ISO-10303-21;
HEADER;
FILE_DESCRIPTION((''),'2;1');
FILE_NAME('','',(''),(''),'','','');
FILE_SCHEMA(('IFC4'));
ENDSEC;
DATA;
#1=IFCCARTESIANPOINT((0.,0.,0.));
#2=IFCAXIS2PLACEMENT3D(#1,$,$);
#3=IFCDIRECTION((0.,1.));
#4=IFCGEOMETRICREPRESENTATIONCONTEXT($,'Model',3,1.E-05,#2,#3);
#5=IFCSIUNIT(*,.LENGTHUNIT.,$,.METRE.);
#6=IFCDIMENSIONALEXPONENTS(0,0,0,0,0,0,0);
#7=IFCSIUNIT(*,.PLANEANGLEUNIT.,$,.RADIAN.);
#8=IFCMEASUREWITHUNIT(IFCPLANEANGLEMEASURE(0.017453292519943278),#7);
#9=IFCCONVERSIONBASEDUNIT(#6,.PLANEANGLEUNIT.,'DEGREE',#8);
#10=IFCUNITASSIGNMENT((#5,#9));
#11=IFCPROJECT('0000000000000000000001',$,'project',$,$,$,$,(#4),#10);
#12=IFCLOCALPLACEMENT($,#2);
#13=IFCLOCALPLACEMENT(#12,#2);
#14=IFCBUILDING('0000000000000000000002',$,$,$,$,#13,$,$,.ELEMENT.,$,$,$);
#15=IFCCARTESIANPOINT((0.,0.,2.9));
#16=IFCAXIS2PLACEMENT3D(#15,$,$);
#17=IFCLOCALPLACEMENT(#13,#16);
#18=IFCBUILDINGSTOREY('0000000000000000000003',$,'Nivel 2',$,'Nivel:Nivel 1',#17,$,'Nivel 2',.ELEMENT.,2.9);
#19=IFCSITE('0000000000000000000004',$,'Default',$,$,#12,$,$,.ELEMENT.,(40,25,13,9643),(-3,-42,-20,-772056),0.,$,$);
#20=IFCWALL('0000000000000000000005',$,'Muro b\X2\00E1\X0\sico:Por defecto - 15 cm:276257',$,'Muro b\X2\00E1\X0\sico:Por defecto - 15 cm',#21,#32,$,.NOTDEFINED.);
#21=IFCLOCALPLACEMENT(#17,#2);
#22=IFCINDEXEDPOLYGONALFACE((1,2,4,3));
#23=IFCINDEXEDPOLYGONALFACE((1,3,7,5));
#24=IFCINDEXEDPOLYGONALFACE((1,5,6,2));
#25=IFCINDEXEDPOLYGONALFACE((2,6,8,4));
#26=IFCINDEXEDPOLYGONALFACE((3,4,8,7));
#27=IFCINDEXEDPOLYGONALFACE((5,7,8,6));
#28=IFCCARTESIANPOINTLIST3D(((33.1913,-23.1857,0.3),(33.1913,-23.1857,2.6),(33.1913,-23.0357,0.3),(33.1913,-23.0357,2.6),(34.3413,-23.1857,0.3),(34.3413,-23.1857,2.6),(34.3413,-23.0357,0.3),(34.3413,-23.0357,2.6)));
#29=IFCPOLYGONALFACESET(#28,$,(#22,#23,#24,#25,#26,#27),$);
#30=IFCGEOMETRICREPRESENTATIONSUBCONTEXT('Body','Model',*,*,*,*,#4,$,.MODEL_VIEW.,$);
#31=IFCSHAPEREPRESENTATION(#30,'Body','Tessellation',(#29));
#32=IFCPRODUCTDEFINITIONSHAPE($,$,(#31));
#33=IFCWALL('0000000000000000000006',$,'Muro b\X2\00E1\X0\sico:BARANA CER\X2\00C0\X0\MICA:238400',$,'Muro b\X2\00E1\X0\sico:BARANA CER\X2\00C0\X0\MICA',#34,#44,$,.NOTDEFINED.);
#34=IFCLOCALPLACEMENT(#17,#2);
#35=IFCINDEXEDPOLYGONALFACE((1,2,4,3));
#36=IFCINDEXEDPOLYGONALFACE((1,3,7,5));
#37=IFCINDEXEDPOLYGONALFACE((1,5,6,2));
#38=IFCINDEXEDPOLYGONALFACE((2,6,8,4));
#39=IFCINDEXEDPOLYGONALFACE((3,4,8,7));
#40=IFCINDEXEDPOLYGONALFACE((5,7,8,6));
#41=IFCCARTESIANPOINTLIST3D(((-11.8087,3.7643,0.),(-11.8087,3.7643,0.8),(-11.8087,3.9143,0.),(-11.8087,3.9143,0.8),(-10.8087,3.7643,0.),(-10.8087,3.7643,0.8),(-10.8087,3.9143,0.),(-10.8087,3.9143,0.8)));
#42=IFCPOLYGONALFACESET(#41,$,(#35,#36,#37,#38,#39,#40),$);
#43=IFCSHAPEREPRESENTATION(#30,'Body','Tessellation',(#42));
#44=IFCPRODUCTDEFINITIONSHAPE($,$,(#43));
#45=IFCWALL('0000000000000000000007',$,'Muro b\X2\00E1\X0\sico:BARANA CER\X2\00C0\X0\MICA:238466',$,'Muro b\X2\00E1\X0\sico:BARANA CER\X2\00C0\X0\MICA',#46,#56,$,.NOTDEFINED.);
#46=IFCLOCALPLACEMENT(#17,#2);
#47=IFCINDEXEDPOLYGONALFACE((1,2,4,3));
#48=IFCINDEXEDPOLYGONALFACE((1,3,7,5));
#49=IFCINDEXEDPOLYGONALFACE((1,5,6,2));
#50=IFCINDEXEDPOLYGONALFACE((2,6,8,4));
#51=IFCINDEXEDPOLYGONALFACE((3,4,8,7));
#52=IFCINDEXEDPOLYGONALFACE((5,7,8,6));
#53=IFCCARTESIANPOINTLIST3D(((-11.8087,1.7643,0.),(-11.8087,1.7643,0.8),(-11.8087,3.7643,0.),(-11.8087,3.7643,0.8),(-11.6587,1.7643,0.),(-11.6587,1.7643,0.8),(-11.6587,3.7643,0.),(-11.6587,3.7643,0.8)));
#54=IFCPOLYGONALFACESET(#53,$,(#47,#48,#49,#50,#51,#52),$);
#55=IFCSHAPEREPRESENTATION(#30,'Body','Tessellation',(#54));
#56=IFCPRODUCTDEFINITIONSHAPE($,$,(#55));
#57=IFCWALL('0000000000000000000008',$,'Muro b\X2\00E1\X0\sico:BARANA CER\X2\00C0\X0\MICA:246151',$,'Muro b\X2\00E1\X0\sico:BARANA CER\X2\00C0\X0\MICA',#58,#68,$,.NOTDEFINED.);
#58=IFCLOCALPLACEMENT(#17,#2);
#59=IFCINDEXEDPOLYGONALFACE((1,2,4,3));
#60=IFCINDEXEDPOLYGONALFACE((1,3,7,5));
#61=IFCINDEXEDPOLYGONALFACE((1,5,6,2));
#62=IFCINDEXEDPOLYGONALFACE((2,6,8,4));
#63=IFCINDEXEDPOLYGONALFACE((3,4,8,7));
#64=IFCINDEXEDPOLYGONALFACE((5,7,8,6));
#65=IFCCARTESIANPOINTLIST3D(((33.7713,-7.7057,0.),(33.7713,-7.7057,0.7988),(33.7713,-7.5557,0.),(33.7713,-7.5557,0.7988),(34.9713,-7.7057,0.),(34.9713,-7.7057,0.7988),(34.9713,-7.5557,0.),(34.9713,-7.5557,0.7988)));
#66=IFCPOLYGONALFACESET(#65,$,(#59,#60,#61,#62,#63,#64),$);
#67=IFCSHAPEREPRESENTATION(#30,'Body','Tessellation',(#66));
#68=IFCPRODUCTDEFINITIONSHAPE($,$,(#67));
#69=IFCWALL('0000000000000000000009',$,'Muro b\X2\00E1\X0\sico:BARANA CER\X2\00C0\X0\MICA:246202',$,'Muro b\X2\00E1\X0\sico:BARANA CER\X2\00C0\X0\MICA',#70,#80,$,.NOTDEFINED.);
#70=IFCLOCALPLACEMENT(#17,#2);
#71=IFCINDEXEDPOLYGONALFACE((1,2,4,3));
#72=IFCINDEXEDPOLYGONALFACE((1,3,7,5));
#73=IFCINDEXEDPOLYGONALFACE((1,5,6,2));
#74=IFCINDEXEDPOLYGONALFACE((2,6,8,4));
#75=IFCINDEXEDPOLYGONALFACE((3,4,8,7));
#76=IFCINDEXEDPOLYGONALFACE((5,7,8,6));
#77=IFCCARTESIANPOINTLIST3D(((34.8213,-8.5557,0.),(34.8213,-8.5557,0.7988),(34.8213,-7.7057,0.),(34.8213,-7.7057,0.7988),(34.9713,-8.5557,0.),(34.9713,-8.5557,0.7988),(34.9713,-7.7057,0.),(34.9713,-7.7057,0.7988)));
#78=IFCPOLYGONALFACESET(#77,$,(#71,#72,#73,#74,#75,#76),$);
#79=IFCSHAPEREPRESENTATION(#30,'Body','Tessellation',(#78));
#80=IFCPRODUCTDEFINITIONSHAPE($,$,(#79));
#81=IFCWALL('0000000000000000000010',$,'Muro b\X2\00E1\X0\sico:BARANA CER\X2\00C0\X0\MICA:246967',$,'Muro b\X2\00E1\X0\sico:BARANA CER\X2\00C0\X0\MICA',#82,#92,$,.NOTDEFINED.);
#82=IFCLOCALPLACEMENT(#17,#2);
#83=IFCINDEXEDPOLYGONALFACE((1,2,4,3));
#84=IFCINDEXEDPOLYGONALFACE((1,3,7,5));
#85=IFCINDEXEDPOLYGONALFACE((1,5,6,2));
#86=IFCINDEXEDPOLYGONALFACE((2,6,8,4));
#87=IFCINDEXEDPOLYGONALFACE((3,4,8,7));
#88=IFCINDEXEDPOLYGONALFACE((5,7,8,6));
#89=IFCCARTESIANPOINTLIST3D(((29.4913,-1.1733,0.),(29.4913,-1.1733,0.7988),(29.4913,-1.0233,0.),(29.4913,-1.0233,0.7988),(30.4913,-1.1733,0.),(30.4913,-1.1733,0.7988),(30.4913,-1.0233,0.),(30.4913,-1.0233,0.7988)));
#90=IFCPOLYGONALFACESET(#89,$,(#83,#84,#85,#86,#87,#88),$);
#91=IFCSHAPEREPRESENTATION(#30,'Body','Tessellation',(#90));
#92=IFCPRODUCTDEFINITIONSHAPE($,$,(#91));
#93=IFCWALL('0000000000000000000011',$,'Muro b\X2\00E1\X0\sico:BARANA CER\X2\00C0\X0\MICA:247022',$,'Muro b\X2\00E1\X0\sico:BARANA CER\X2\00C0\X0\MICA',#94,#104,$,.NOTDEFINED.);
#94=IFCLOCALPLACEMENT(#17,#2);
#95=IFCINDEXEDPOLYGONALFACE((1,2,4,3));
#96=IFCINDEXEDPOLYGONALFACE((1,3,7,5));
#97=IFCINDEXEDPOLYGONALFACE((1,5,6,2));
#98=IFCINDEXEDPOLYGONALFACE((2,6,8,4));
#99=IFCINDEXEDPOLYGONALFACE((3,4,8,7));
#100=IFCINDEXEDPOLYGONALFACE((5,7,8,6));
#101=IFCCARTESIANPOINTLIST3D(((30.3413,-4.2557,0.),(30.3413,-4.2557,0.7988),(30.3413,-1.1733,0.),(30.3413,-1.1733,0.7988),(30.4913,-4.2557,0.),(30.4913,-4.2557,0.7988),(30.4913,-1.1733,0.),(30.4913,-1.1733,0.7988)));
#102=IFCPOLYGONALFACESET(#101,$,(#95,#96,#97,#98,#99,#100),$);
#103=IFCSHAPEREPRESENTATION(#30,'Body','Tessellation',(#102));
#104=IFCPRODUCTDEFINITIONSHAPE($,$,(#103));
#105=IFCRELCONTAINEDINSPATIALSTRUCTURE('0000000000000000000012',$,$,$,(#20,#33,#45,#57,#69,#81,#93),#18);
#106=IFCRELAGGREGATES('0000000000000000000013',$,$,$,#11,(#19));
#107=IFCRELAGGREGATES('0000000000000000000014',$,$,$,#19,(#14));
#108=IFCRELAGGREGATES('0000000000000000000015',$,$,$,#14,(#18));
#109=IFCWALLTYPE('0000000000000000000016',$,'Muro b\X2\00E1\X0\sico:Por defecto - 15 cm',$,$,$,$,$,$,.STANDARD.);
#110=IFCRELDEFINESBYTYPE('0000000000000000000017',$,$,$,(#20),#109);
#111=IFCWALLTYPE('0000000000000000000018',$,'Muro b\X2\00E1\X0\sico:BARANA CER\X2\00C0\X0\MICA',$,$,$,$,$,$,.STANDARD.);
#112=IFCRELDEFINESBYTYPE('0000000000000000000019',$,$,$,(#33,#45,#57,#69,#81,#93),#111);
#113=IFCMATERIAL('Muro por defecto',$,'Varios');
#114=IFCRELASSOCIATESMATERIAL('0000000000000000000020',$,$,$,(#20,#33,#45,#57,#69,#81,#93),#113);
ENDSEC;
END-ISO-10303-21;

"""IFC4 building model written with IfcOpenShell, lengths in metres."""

from ifc_helpers import new_model, entity, si_unit, converted_unit, direction, frame, origin, place, context, subcontext, project, spatial, indexed_curve, outline, extrude, material, type_object, element, save


model = new_model("IFC4")

# Units and contexts
model_context = context("Model", 3, precision=1e-05, world=origin(), true_north=direction((0.0, 1.0)))
body_context = subcontext(model_context, "Body", "Model", "MODEL_VIEW")
ifc_project = project(units=[si_unit("LENGTHUNIT", "METRE"), converted_unit("PLANEANGLEUNIT", "DEGREE", entity("IfcPlaneAngleMeasure", 0.017453292519943278), si_unit("PLANEANGLEUNIT", "RADIAN"), dimensions=[0, 0, 0, 0, 0, 0, 0])], contexts=[model_context])

# Site, building, storey
site_placement = place(None, origin())
site = spatial("IfcSite", under=ifc_project, at=site_placement, Name="Default", CompositionType="ELEMENT", RefLatitude=(40, 25, 13, 9643), RefLongitude=(-3, -42, -20, -772056), RefElevation=0.0)
building_placement = place(site_placement, origin())
building = spatial("IfcBuilding", under=site, at=building_placement, CompositionType="ELEMENT")
storey_placement = place(building_placement, frame((0.0, 0.0, 2.9)))
storey = spatial("IfcBuildingStorey", under=building, at=storey_placement, Name="Nivel 2", ObjectType="Nivel:Nivel 1", LongName="Nivel 2", CompositionType="ELEMENT", Elevation=2.9)

# Shared definitions
ifc_material_1 = material(Name="Muro por defecto", Category="Varios")
wall_type_1 = type_object("IfcWallType", Name="Muro básico:Por defecto - 15 cm", PredefinedType="STANDARD")

# Walls
wall_1_placement = place(storey_placement, frame((33.1913, -23.1107, 0.3)))
element("IfcWall", 1, at=wall_1_placement, inside=storey, type_object=wall_type_1, material=ifc_material_1, Name="Muro básico:Por defecto - 15 cm:276257", ObjectType="Muro básico:Por defecto - 15 cm", PredefinedType="NOTDEFINED", context=body_context, shape_type="SweptSolid", body=[
    extrude(outline(indexed_curve([(1.15, 0.075), (0.0, 0.075), (0.0, -0.075), (1.15, -0.075), (1.15, 0.075)], self_intersect=False)), origin(), (0.0, 0.0, 1.0), 2.3),
])
wall_type_2 = type_object("IfcWallType", Name="Muro básico:BARANA CERÀMICA", PredefinedType="STANDARD")
wall_2_placement = place(storey_placement, frame((-10.8087, 3.8393, 0.0), z_axis=(0.0, 0.0, 1.0), x_axis=(-1.0, 0.0, 0.0)))
element("IfcWall", 2, at=wall_2_placement, inside=storey, type_object=wall_type_2, material=ifc_material_1, Name="Muro básico:BARANA CERÀMICA:238400", ObjectType="Muro básico:BARANA CERÀMICA", PredefinedType="NOTDEFINED", context=body_context, shape_type="SweptSolid", body=[
    extrude(outline(indexed_curve([(1.0, 0.075), (0.0, 0.075), (0.0, -0.075), (1.0, -0.075), (1.0, 0.075)], self_intersect=False)), origin(), (0.0, 0.0, 1.0), 0.8),
])
wall_3_placement = place(storey_placement, frame((-11.7337, 3.7643, 0.0), z_axis=(0.0, 0.0, 1.0), x_axis=(0.0, -1.0, 0.0)))
element("IfcWall", 3, at=wall_3_placement, inside=storey, type_object=wall_type_2, material=ifc_material_1, Name="Muro básico:BARANA CERÀMICA:238466", ObjectType="Muro básico:BARANA CERÀMICA", PredefinedType="NOTDEFINED", context=body_context, shape_type="SweptSolid", body=[
    extrude(outline(indexed_curve([(2.0, 0.075), (0.0, 0.075), (0.0, -0.075), (2.0, -0.075), (2.0, 0.075)], self_intersect=False)), origin(), (0.0, 0.0, 1.0), 0.8),
])
wall_4_placement = place(storey_placement, frame((33.7713, -7.6307, 0.0)))
element("IfcWall", 4, at=wall_4_placement, inside=storey, type_object=wall_type_2, material=ifc_material_1, Name="Muro básico:BARANA CERÀMICA:246151", ObjectType="Muro básico:BARANA CERÀMICA", PredefinedType="NOTDEFINED", context=body_context, shape_type="SweptSolid", body=[
    extrude(outline(indexed_curve([(1.2, 0.075), (0.0, 0.075), (0.0, -0.075), (1.2, -0.075), (1.2, 0.075)], self_intersect=False)), origin(), (0.0, 0.0, 1.0), 0.7988),
])
wall_5_placement = place(storey_placement, frame((34.8963, -7.7057, 0.0), z_axis=(0.0, 0.0, 1.0), x_axis=(0.0, -1.0, 0.0)))
element("IfcWall", 5, at=wall_5_placement, inside=storey, type_object=wall_type_2, material=ifc_material_1, Name="Muro básico:BARANA CERÀMICA:246202", ObjectType="Muro básico:BARANA CERÀMICA", PredefinedType="NOTDEFINED", context=body_context, shape_type="SweptSolid", body=[
    extrude(outline(indexed_curve([(0.85, 0.075), (0.0, 0.075), (0.0, -0.075), (0.85, -0.075), (0.85, 0.075)], self_intersect=False)), origin(), (0.0, 0.0, 1.0), 0.7988),
])
wall_6_placement = place(storey_placement, frame((29.4913, -1.0983, 0.0)))
element("IfcWall", 6, at=wall_6_placement, inside=storey, type_object=wall_type_2, material=ifc_material_1, Name="Muro básico:BARANA CERÀMICA:246967", ObjectType="Muro básico:BARANA CERÀMICA", PredefinedType="NOTDEFINED", context=body_context, shape_type="SweptSolid", body=[
    extrude(outline(indexed_curve([(1.0, 0.075), (0.0, 0.075), (0.0, -0.075), (1.0, -0.075), (1.0, 0.075)], self_intersect=False)), origin(), (0.0, 0.0, 1.0), 0.7988),
])
wall_7_placement = place(storey_placement, frame((30.4163, -1.1733, 0.0), z_axis=(0.0, 0.0, 1.0), x_axis=(0.0, -1.0, 0.0)))
element("IfcWall", 7, at=wall_7_placement, inside=storey, type_object=wall_type_2, material=ifc_material_1, Name="Muro básico:BARANA CERÀMICA:247022", ObjectType="Muro básico:BARANA CERÀMICA", PredefinedType="NOTDEFINED", context=body_context, shape_type="SweptSolid", body=[
    extrude(outline(indexed_curve([(3.0824, 0.075), (0.0, 0.075), (0.0, -0.075), (3.0824, -0.075), (3.0824, 0.075)], self_intersect=False)), origin(), (0.0, 0.0, 1.0), 0.7988),
])

save(model, "model.ifc")
